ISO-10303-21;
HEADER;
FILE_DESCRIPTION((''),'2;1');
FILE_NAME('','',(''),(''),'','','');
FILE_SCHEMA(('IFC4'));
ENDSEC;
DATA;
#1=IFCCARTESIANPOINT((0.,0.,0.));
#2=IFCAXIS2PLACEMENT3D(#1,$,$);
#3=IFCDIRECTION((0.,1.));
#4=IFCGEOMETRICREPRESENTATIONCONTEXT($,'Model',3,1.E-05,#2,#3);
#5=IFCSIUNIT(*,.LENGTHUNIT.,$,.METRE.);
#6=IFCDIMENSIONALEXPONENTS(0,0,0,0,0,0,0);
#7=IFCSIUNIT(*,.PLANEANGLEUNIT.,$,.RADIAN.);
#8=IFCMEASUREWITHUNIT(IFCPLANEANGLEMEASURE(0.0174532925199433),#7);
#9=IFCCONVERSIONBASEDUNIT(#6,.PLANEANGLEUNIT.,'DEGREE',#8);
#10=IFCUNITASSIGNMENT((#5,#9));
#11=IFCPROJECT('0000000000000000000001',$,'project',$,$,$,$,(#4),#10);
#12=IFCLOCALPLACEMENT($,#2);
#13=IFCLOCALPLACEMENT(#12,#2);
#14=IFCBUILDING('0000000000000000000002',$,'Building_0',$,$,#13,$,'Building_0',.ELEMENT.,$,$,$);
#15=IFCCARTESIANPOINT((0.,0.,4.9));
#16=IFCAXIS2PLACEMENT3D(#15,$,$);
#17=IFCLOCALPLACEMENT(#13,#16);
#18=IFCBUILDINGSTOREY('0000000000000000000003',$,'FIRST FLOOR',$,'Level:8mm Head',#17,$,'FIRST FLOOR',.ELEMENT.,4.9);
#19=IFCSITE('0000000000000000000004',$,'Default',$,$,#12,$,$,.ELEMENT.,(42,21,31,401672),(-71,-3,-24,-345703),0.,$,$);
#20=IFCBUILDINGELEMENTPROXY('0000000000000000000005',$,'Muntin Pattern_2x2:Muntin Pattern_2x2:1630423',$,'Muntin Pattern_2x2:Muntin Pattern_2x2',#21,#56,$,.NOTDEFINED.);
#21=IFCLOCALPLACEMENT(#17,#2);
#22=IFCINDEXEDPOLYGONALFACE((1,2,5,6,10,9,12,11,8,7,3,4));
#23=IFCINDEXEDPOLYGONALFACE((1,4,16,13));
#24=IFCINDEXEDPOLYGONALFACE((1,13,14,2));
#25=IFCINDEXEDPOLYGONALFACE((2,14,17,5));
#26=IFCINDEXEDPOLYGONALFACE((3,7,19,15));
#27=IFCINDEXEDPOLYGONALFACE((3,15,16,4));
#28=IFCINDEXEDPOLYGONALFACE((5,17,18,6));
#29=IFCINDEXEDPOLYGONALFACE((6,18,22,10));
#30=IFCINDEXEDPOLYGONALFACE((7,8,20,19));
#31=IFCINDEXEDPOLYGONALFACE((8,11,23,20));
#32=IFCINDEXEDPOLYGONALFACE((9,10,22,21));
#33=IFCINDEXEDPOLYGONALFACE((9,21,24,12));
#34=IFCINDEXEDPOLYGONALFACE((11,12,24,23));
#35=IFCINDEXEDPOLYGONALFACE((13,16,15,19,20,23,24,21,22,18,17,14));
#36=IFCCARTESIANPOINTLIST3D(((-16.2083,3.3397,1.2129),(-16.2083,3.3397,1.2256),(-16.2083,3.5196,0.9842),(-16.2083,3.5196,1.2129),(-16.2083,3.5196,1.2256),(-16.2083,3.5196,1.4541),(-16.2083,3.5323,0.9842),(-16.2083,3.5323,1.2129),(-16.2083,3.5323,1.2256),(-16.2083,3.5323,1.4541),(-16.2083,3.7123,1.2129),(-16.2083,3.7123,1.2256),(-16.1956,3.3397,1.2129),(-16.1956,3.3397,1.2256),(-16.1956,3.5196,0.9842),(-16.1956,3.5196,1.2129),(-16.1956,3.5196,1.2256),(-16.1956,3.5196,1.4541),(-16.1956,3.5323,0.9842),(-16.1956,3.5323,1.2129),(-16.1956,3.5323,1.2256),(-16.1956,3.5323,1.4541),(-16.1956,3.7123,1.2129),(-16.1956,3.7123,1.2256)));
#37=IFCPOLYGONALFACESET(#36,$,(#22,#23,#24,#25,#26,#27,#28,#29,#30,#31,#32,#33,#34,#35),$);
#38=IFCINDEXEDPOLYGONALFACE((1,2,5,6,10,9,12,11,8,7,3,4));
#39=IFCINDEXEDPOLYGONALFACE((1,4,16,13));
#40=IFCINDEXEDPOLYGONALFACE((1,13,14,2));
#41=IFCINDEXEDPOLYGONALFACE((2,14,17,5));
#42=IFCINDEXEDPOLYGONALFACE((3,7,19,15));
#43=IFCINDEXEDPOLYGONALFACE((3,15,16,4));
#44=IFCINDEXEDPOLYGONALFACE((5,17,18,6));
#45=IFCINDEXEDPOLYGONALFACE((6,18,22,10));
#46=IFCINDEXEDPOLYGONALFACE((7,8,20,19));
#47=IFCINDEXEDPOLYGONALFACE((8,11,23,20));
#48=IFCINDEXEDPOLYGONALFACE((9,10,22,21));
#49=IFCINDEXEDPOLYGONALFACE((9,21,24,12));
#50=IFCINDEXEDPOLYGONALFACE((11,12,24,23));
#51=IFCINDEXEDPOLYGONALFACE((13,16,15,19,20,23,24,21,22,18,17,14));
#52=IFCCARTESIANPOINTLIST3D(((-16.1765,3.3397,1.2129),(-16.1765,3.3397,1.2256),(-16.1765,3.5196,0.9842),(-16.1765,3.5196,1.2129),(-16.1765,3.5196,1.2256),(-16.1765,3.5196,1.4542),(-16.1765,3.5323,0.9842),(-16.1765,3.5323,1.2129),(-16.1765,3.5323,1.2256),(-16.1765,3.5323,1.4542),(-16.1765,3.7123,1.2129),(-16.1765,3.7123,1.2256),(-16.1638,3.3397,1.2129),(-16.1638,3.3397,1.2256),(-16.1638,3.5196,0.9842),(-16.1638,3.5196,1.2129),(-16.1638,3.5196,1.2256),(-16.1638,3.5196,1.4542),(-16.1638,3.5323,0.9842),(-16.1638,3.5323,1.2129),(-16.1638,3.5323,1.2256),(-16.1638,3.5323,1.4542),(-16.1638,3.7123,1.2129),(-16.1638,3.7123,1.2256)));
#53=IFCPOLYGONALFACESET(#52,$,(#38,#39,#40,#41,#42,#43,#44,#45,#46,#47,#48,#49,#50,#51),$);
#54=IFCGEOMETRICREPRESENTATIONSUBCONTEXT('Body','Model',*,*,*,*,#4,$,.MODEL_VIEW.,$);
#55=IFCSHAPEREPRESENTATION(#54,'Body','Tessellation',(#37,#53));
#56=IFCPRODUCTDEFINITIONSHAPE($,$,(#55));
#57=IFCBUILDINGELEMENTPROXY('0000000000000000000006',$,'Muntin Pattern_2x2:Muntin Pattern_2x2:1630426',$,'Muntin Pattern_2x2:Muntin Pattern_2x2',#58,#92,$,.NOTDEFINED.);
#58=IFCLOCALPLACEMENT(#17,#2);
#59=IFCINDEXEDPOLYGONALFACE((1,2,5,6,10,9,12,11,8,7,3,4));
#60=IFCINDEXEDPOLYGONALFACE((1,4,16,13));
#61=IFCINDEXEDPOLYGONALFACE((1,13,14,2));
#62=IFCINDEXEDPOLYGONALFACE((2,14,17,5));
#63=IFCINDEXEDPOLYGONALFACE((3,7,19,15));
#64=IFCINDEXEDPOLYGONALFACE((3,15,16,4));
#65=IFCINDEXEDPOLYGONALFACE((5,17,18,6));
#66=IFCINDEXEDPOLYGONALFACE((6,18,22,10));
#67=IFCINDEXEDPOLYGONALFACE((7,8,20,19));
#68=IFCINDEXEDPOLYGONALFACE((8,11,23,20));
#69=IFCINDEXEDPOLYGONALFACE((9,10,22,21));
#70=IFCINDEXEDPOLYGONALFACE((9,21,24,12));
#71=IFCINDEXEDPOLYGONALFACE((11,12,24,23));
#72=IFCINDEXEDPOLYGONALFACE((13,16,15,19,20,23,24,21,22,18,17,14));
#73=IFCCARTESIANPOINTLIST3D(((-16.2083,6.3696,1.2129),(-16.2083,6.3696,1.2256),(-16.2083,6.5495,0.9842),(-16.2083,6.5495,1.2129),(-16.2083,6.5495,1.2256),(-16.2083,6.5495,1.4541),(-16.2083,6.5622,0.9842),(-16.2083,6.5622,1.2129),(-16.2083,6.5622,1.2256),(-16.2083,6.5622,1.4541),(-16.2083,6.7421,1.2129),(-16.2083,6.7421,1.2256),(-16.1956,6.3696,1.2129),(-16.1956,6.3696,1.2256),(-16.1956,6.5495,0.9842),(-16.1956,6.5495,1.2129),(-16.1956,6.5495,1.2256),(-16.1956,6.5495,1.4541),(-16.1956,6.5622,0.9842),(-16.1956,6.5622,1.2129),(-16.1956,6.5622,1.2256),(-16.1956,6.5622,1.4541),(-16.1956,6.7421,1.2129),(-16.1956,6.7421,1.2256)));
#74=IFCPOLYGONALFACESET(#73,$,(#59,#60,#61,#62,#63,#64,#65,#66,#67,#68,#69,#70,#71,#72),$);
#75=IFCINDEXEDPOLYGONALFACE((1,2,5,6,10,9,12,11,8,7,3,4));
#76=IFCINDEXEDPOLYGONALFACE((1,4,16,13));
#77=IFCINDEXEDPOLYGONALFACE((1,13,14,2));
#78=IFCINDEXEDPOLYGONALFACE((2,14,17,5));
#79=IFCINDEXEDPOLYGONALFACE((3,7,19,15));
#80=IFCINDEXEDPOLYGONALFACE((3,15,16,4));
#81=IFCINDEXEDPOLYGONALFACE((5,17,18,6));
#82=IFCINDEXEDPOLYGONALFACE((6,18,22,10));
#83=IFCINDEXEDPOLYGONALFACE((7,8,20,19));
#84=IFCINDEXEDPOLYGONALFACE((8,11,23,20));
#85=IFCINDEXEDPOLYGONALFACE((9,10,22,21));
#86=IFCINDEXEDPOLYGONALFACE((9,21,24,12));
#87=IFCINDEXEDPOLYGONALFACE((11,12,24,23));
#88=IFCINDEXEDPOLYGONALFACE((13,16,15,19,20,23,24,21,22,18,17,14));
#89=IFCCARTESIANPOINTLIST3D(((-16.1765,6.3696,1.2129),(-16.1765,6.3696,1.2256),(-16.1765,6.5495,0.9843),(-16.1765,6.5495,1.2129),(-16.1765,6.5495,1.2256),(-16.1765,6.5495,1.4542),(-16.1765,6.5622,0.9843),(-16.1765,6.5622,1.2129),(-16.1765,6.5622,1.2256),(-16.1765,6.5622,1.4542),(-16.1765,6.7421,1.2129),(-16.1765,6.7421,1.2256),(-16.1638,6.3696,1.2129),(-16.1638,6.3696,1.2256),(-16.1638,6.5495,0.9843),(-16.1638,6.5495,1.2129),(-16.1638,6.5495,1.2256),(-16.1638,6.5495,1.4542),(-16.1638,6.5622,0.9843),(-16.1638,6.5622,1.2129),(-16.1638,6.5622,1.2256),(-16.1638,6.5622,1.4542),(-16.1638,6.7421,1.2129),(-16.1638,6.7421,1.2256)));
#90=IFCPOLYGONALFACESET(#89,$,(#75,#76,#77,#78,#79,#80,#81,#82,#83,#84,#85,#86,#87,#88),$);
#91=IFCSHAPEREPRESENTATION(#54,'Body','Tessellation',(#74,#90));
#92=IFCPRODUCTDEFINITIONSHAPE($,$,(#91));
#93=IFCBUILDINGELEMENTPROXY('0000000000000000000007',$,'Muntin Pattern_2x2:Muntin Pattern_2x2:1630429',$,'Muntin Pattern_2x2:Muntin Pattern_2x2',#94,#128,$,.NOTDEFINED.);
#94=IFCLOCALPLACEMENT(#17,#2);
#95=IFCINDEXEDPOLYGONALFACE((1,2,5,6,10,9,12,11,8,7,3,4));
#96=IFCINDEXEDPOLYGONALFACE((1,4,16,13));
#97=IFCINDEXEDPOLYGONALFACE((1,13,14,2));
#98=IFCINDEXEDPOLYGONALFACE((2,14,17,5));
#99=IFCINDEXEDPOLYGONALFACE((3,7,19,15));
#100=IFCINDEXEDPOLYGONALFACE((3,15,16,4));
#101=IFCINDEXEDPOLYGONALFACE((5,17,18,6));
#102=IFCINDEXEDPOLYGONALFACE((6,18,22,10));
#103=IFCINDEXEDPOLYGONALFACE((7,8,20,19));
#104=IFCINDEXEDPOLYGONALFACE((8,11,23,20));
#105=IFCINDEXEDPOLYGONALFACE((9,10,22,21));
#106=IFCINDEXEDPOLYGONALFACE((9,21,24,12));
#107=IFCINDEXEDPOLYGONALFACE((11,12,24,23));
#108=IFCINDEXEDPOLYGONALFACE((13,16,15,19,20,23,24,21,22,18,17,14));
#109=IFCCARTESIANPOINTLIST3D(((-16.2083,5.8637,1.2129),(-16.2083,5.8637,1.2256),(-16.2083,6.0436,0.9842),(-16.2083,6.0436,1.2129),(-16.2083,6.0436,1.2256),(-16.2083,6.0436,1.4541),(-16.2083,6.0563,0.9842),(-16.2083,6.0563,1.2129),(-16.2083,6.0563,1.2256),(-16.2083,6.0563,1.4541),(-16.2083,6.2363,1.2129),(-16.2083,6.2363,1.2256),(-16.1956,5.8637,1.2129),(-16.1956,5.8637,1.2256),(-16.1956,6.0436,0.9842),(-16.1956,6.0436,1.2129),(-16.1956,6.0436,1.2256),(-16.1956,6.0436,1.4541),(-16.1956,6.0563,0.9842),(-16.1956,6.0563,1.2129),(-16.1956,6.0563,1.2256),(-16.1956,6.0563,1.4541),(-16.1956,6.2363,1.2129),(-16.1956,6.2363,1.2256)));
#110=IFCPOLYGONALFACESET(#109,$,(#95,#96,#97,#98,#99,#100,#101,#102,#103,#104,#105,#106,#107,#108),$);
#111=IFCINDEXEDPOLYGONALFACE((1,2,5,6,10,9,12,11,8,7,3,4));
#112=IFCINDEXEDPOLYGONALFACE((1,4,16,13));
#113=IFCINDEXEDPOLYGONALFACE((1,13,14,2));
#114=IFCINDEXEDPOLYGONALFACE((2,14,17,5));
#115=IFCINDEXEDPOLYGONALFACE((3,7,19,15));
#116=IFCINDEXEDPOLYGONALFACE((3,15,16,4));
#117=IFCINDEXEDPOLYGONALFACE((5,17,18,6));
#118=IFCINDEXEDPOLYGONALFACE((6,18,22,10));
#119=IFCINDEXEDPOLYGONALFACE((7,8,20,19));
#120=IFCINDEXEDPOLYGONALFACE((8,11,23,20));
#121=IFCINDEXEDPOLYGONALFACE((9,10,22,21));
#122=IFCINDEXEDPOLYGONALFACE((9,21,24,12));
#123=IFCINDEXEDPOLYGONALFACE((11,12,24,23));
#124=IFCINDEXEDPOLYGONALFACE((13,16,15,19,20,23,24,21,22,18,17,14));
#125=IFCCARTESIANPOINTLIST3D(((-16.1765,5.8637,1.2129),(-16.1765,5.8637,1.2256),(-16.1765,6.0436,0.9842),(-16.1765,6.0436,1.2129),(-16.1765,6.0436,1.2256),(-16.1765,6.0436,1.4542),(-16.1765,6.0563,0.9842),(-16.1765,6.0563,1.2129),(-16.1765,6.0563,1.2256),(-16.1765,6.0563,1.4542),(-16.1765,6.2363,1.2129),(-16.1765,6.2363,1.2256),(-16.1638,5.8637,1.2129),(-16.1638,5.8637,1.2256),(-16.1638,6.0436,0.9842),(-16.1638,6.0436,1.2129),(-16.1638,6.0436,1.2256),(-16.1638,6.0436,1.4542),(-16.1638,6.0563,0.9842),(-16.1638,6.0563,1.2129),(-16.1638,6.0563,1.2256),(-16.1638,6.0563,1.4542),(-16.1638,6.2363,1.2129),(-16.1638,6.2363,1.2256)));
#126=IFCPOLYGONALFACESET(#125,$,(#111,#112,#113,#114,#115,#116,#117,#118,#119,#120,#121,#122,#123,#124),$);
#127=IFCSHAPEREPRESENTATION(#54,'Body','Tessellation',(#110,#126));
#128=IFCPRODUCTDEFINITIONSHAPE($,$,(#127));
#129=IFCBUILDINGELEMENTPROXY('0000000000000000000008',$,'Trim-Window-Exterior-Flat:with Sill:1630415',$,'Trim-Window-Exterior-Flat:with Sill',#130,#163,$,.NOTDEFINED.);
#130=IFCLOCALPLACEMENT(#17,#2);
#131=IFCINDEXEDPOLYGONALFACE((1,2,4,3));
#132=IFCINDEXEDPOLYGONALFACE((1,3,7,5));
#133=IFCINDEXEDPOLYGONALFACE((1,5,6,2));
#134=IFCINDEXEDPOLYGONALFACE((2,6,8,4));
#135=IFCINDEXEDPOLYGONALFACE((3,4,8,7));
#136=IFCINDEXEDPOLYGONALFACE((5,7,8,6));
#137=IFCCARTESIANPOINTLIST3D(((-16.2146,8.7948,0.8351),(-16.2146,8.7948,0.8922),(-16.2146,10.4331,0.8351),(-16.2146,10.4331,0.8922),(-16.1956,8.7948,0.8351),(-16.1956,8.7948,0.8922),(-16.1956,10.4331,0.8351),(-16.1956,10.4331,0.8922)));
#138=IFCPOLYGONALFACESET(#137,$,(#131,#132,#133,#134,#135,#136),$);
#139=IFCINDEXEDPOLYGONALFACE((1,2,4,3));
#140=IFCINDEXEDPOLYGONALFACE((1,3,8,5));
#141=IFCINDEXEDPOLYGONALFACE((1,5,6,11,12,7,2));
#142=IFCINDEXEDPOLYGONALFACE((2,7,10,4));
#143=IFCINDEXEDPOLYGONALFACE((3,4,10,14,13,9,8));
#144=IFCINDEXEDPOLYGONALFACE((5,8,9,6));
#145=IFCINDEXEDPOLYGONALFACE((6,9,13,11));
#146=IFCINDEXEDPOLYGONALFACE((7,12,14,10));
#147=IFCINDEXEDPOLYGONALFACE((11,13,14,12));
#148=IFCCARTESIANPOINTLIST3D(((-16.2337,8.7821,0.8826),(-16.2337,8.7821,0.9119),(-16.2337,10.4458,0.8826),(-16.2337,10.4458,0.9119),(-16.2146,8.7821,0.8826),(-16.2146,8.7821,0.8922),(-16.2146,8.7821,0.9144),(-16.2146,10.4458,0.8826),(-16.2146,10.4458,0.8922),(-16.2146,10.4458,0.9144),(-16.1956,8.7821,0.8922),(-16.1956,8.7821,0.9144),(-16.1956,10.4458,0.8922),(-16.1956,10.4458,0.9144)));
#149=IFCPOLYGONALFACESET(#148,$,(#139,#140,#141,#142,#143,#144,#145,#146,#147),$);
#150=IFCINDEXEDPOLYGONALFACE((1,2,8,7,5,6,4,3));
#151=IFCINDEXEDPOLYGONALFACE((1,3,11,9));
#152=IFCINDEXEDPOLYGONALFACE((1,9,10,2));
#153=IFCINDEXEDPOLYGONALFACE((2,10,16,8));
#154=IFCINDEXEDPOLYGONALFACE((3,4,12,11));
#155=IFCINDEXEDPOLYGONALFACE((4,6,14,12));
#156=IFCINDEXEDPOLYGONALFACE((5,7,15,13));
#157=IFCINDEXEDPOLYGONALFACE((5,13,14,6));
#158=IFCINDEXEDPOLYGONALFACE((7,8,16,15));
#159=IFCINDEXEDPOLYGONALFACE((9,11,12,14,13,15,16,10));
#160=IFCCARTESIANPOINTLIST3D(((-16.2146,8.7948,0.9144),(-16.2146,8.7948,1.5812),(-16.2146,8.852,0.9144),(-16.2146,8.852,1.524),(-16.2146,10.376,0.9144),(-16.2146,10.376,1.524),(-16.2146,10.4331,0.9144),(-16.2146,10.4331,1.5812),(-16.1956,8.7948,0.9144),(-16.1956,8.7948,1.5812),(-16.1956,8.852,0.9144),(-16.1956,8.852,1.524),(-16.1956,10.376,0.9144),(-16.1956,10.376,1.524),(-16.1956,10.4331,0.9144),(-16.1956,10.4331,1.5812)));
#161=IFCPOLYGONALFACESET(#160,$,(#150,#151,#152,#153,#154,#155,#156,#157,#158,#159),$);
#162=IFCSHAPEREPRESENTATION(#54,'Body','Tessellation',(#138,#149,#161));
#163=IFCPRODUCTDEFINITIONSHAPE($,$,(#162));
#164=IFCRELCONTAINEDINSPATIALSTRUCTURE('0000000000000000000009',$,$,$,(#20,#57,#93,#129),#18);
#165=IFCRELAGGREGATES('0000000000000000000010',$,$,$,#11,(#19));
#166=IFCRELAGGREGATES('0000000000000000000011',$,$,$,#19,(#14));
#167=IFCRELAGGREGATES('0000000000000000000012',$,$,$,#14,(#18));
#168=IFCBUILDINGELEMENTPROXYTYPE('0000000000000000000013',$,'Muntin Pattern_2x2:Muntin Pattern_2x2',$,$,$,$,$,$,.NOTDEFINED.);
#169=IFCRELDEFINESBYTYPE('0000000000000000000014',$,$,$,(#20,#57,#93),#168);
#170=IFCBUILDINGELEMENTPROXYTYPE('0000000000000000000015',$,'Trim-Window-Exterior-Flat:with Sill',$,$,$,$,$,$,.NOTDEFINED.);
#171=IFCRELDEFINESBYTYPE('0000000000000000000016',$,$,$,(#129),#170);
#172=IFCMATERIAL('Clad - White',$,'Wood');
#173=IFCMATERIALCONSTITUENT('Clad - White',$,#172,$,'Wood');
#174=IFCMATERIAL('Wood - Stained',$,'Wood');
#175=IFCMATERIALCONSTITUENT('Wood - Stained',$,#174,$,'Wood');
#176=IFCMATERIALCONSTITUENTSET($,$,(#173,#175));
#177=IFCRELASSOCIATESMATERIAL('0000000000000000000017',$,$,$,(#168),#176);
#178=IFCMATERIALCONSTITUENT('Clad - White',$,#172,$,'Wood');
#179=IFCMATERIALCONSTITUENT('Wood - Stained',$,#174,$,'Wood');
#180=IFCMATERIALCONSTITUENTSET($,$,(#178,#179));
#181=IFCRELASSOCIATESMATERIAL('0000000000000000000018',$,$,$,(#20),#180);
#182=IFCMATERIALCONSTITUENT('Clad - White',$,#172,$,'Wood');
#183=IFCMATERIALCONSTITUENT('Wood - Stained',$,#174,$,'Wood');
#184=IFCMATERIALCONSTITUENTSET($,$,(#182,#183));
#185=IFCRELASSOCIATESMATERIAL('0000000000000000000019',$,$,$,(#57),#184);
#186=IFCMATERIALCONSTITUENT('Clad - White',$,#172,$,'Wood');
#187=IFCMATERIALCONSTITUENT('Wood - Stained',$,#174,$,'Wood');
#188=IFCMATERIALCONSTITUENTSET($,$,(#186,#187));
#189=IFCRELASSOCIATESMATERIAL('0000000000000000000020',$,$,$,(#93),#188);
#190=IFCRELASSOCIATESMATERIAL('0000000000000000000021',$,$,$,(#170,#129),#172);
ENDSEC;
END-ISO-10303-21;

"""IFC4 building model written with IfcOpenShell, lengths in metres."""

from ifc_helpers import new_model, entity, si_unit, converted_unit, direction, frame, origin, place, context, subcontext, project, spatial, indexed_curve, outline, extrude, source, transform, mapped, material, constituent, constituent_set, type_object, type_shapes, element, save


model = new_model("IFC4")

# Units and contexts
model_context = context("Model", 3, precision=1e-05, world=origin(), true_north=direction((0.0, 1.0)))
body_context = subcontext(model_context, "Body", "Model", "MODEL_VIEW")
ifc_project = project(units=[si_unit("LENGTHUNIT", "METRE"), converted_unit("PLANEANGLEUNIT", "DEGREE", entity("IfcPlaneAngleMeasure", 0.0174532925199433), si_unit("PLANEANGLEUNIT", "RADIAN"), dimensions=[0, 0, 0, 0, 0, 0, 0])], contexts=[model_context])

# Site, building, storey
site_placement = place(None, origin())
site = spatial("IfcSite", under=ifc_project, at=site_placement, Name="Default", CompositionType="ELEMENT", RefLatitude=(42, 21, 31, 401672), RefLongitude=(-71, -3, -24, -345703), RefElevation=0.0)
building_placement = place(site_placement, origin())
building = spatial("IfcBuilding", under=site, at=building_placement, Name="Building_0", LongName="Building_0", CompositionType="ELEMENT")
storey_placement = place(building_placement, frame((0.0, 0.0, 4.9)))
storey = spatial("IfcBuildingStorey", under=building, at=storey_placement, Name="FIRST FLOOR", ObjectType="Level:8mm Head", LongName="FIRST FLOOR", CompositionType="ELEMENT", Elevation=4.9)

# Shared definitions
ifc_material_1 = material(Name="Clad - White", Category="Wood")

# Building element proxies
ifc_material_2 = material(Name="Wood - Stained", Category="Wood")
ifc_constituent_1 = constituent(ifc_material_1, Name="Clad - White", Category="Wood")
ifc_constituent_2 = constituent(ifc_material_2, Name="Wood - Stained", Category="Wood")
ifc_constituent_set_1 = constituent_set(constituents=[ifc_constituent_1, ifc_constituent_2])
building_element_proxy_type_1 = type_object("IfcBuildingElementProxyType", Name="Muntin Pattern_2x2:Muntin Pattern_2x2", PredefinedType="NOTDEFINED", material=ifc_constituent_set_1)
shared_shape_1 = source(origin(), body_context, "Body", "SweptSolid", [
    extrude(outline(indexed_curve([(0.0064, -0.0064), (0.2349, -0.0064), (0.2349, 0.0063), (0.0064, 0.0063), (0.0064, 0.1863), (-0.0063, 0.1863), (-0.0063, 0.0063), (-0.235, 0.0063), (-0.235, -0.0064), (-0.0063, -0.0064), (-0.0063, -0.1863), (0.0064, -0.1863), (0.0064, -0.0064)], self_intersect=False)), frame((0.0, -0.0222, 0.2349), z_axis=(0.0, 1.0, 0.0), x_axis=(0.0, 0.0, 1.0)), (0.0, 0.0, 1.0), 0.0127),
    extrude(outline(indexed_curve([(0.0064, -0.0064), (0.235, -0.0064), (0.235, 0.0063), (0.0064, 0.0063), (0.0064, 0.1863), (-0.0063, 0.1863), (-0.0063, 0.0063), (-0.235, 0.0063), (-0.235, -0.0064), (-0.0063, -0.0064), (-0.0063, -0.1863), (0.0064, -0.1863), (0.0064, -0.0064)], self_intersect=False)), frame((0.0, 0.0095, 0.235), z_axis=(0.0, 1.0, 0.0), x_axis=(0.0, 0.0, 1.0)), (0.0, 0.0, 1.0), 0.0127),
])
type_shapes(building_element_proxy_type_1, [shared_shape_1])
ifc_constituent_3 = constituent(ifc_material_1, Name="Clad - White", Category="Wood")
ifc_constituent_4 = constituent(ifc_material_2, Name="Wood - Stained", Category="Wood")
ifc_constituent_set_2 = constituent_set(constituents=[ifc_constituent_3, ifc_constituent_4])
proxy_1_placement = place(storey_placement, frame((-16.1861, 3.526, 0.9842), z_axis=(0.0, 0.0, 1.0), x_axis=(0.0, -1.0, 0.0)))
element("IfcBuildingElementProxy", 1, at=proxy_1_placement, inside=storey, type_object=building_element_proxy_type_1, material=ifc_constituent_set_2, Name="Muntin Pattern_2x2:Muntin Pattern_2x2:1630423", ObjectType="Muntin Pattern_2x2:Muntin Pattern_2x2", PredefinedType="NOTDEFINED", context=body_context, shape_type="MappedRepresentation", body=[
    mapped(shared_shape_1, transform((0.0, 0.0, 0.0), scale=1.0)),
])
ifc_constituent_5 = constituent(ifc_material_1, Name="Clad - White", Category="Wood")
ifc_constituent_6 = constituent(ifc_material_2, Name="Wood - Stained", Category="Wood")
ifc_constituent_set_3 = constituent_set(constituents=[ifc_constituent_5, ifc_constituent_6])
proxy_2_placement = place(storey_placement, frame((-16.1861, 6.5559, 0.9843), z_axis=(0.0, 0.0, 1.0), x_axis=(0.0, -1.0, 0.0)))
element("IfcBuildingElementProxy", 2, at=proxy_2_placement, inside=storey, type_object=building_element_proxy_type_1, material=ifc_constituent_set_3, Name="Muntin Pattern_2x2:Muntin Pattern_2x2:1630426", ObjectType="Muntin Pattern_2x2:Muntin Pattern_2x2", PredefinedType="NOTDEFINED", context=body_context, shape_type="MappedRepresentation", body=[
    mapped(shared_shape_1, transform((0.0, 0.0, 0.0), scale=1.0)),
])
ifc_constituent_7 = constituent(ifc_material_1, Name="Clad - White", Category="Wood")
ifc_constituent_8 = constituent(ifc_material_2, Name="Wood - Stained", Category="Wood")
ifc_constituent_set_4 = constituent_set(constituents=[ifc_constituent_7, ifc_constituent_8])
proxy_3_placement = place(storey_placement, frame((-16.1861, 6.05, 0.9842), z_axis=(0.0, 0.0, 1.0), x_axis=(0.0, -1.0, 0.0)))
element("IfcBuildingElementProxy", 3, at=proxy_3_placement, inside=storey, type_object=building_element_proxy_type_1, material=ifc_constituent_set_4, Name="Muntin Pattern_2x2:Muntin Pattern_2x2:1630429", ObjectType="Muntin Pattern_2x2:Muntin Pattern_2x2", PredefinedType="NOTDEFINED", context=body_context, shape_type="MappedRepresentation", body=[
    mapped(shared_shape_1, transform((0.0, 0.0, 0.0), scale=1.0)),
])
building_element_proxy_type_2 = type_object("IfcBuildingElementProxyType", Name="Trim-Window-Exterior-Flat:with Sill", PredefinedType="NOTDEFINED", material=ifc_material_1)
shared_shape_2 = source(origin(), body_context, "Body", "SweptSolid", [
    extrude(outline(indexed_curve([(-0.8191, -0.0286), (0.8191, -0.0286), (0.8191, 0.0286), (-0.8191, 0.0286), (-0.8191, -0.0286)], self_intersect=False)), frame((0.0, -0.6604, 0.0), z_axis=(0.0, 0.0, 1.0), x_axis=(-1.0, 0.0, 0.0)), (0.0, 0.0, 1.0), 0.0191),
    extrude(outline(indexed_curve([(-0.019, -0.016), (0.0, -0.016), (0.0, -0.0064), (0.019, -0.0064), (0.019, 0.0158), (0.0, 0.0158), (-0.019, 0.0133), (-0.019, -0.016)], self_intersect=False)), frame((-0.8318, -0.6254, 0.019), z_axis=(1.0, 0.0, 0.0), x_axis=(0.0, 0.0, -1.0)), (0.0, 0.0, 1.0), 1.6637),
    extrude(outline(indexed_curve([(-0.3477, -0.8192), (0.3191, -0.8192), (0.3191, -0.762), (-0.2905, -0.762), (-0.2905, 0.762), (0.3191, 0.762), (0.3191, 0.8191), (-0.3477, 0.8191), (-0.3477, -0.8192)], self_intersect=False)), frame((0.0, -0.2905, 0.0), z_axis=(0.0, 0.0, 1.0), x_axis=(0.0, -1.0, 0.0)), (0.0, 0.0, 1.0), 0.0191),
])
type_shapes(building_element_proxy_type_2, [shared_shape_2])
for number, where, z_axis, x_axis, name in (
    (4, (-16.1956, 9.614, 1.524), (-1.0, 0.0, 0.0), (0.0, -1.0, 0.0), "Trim-Window-Exterior-Flat:with Sill:1630415"),
):
    element("IfcBuildingElementProxy", number, at=place(storey_placement, frame(where, z_axis=z_axis, x_axis=x_axis)), inside=storey, type_object=building_element_proxy_type_2, material=ifc_material_1, Name=name, ObjectType="Trim-Window-Exterior-Flat:with Sill", PredefinedType="NOTDEFINED", context=body_context, shape_type="MappedRepresentation", body=[
        mapped(shared_shape_2, transform((0.0, 0.0, 0.0), scale=1.0)),
    ])

save(model, "model.ifc")
